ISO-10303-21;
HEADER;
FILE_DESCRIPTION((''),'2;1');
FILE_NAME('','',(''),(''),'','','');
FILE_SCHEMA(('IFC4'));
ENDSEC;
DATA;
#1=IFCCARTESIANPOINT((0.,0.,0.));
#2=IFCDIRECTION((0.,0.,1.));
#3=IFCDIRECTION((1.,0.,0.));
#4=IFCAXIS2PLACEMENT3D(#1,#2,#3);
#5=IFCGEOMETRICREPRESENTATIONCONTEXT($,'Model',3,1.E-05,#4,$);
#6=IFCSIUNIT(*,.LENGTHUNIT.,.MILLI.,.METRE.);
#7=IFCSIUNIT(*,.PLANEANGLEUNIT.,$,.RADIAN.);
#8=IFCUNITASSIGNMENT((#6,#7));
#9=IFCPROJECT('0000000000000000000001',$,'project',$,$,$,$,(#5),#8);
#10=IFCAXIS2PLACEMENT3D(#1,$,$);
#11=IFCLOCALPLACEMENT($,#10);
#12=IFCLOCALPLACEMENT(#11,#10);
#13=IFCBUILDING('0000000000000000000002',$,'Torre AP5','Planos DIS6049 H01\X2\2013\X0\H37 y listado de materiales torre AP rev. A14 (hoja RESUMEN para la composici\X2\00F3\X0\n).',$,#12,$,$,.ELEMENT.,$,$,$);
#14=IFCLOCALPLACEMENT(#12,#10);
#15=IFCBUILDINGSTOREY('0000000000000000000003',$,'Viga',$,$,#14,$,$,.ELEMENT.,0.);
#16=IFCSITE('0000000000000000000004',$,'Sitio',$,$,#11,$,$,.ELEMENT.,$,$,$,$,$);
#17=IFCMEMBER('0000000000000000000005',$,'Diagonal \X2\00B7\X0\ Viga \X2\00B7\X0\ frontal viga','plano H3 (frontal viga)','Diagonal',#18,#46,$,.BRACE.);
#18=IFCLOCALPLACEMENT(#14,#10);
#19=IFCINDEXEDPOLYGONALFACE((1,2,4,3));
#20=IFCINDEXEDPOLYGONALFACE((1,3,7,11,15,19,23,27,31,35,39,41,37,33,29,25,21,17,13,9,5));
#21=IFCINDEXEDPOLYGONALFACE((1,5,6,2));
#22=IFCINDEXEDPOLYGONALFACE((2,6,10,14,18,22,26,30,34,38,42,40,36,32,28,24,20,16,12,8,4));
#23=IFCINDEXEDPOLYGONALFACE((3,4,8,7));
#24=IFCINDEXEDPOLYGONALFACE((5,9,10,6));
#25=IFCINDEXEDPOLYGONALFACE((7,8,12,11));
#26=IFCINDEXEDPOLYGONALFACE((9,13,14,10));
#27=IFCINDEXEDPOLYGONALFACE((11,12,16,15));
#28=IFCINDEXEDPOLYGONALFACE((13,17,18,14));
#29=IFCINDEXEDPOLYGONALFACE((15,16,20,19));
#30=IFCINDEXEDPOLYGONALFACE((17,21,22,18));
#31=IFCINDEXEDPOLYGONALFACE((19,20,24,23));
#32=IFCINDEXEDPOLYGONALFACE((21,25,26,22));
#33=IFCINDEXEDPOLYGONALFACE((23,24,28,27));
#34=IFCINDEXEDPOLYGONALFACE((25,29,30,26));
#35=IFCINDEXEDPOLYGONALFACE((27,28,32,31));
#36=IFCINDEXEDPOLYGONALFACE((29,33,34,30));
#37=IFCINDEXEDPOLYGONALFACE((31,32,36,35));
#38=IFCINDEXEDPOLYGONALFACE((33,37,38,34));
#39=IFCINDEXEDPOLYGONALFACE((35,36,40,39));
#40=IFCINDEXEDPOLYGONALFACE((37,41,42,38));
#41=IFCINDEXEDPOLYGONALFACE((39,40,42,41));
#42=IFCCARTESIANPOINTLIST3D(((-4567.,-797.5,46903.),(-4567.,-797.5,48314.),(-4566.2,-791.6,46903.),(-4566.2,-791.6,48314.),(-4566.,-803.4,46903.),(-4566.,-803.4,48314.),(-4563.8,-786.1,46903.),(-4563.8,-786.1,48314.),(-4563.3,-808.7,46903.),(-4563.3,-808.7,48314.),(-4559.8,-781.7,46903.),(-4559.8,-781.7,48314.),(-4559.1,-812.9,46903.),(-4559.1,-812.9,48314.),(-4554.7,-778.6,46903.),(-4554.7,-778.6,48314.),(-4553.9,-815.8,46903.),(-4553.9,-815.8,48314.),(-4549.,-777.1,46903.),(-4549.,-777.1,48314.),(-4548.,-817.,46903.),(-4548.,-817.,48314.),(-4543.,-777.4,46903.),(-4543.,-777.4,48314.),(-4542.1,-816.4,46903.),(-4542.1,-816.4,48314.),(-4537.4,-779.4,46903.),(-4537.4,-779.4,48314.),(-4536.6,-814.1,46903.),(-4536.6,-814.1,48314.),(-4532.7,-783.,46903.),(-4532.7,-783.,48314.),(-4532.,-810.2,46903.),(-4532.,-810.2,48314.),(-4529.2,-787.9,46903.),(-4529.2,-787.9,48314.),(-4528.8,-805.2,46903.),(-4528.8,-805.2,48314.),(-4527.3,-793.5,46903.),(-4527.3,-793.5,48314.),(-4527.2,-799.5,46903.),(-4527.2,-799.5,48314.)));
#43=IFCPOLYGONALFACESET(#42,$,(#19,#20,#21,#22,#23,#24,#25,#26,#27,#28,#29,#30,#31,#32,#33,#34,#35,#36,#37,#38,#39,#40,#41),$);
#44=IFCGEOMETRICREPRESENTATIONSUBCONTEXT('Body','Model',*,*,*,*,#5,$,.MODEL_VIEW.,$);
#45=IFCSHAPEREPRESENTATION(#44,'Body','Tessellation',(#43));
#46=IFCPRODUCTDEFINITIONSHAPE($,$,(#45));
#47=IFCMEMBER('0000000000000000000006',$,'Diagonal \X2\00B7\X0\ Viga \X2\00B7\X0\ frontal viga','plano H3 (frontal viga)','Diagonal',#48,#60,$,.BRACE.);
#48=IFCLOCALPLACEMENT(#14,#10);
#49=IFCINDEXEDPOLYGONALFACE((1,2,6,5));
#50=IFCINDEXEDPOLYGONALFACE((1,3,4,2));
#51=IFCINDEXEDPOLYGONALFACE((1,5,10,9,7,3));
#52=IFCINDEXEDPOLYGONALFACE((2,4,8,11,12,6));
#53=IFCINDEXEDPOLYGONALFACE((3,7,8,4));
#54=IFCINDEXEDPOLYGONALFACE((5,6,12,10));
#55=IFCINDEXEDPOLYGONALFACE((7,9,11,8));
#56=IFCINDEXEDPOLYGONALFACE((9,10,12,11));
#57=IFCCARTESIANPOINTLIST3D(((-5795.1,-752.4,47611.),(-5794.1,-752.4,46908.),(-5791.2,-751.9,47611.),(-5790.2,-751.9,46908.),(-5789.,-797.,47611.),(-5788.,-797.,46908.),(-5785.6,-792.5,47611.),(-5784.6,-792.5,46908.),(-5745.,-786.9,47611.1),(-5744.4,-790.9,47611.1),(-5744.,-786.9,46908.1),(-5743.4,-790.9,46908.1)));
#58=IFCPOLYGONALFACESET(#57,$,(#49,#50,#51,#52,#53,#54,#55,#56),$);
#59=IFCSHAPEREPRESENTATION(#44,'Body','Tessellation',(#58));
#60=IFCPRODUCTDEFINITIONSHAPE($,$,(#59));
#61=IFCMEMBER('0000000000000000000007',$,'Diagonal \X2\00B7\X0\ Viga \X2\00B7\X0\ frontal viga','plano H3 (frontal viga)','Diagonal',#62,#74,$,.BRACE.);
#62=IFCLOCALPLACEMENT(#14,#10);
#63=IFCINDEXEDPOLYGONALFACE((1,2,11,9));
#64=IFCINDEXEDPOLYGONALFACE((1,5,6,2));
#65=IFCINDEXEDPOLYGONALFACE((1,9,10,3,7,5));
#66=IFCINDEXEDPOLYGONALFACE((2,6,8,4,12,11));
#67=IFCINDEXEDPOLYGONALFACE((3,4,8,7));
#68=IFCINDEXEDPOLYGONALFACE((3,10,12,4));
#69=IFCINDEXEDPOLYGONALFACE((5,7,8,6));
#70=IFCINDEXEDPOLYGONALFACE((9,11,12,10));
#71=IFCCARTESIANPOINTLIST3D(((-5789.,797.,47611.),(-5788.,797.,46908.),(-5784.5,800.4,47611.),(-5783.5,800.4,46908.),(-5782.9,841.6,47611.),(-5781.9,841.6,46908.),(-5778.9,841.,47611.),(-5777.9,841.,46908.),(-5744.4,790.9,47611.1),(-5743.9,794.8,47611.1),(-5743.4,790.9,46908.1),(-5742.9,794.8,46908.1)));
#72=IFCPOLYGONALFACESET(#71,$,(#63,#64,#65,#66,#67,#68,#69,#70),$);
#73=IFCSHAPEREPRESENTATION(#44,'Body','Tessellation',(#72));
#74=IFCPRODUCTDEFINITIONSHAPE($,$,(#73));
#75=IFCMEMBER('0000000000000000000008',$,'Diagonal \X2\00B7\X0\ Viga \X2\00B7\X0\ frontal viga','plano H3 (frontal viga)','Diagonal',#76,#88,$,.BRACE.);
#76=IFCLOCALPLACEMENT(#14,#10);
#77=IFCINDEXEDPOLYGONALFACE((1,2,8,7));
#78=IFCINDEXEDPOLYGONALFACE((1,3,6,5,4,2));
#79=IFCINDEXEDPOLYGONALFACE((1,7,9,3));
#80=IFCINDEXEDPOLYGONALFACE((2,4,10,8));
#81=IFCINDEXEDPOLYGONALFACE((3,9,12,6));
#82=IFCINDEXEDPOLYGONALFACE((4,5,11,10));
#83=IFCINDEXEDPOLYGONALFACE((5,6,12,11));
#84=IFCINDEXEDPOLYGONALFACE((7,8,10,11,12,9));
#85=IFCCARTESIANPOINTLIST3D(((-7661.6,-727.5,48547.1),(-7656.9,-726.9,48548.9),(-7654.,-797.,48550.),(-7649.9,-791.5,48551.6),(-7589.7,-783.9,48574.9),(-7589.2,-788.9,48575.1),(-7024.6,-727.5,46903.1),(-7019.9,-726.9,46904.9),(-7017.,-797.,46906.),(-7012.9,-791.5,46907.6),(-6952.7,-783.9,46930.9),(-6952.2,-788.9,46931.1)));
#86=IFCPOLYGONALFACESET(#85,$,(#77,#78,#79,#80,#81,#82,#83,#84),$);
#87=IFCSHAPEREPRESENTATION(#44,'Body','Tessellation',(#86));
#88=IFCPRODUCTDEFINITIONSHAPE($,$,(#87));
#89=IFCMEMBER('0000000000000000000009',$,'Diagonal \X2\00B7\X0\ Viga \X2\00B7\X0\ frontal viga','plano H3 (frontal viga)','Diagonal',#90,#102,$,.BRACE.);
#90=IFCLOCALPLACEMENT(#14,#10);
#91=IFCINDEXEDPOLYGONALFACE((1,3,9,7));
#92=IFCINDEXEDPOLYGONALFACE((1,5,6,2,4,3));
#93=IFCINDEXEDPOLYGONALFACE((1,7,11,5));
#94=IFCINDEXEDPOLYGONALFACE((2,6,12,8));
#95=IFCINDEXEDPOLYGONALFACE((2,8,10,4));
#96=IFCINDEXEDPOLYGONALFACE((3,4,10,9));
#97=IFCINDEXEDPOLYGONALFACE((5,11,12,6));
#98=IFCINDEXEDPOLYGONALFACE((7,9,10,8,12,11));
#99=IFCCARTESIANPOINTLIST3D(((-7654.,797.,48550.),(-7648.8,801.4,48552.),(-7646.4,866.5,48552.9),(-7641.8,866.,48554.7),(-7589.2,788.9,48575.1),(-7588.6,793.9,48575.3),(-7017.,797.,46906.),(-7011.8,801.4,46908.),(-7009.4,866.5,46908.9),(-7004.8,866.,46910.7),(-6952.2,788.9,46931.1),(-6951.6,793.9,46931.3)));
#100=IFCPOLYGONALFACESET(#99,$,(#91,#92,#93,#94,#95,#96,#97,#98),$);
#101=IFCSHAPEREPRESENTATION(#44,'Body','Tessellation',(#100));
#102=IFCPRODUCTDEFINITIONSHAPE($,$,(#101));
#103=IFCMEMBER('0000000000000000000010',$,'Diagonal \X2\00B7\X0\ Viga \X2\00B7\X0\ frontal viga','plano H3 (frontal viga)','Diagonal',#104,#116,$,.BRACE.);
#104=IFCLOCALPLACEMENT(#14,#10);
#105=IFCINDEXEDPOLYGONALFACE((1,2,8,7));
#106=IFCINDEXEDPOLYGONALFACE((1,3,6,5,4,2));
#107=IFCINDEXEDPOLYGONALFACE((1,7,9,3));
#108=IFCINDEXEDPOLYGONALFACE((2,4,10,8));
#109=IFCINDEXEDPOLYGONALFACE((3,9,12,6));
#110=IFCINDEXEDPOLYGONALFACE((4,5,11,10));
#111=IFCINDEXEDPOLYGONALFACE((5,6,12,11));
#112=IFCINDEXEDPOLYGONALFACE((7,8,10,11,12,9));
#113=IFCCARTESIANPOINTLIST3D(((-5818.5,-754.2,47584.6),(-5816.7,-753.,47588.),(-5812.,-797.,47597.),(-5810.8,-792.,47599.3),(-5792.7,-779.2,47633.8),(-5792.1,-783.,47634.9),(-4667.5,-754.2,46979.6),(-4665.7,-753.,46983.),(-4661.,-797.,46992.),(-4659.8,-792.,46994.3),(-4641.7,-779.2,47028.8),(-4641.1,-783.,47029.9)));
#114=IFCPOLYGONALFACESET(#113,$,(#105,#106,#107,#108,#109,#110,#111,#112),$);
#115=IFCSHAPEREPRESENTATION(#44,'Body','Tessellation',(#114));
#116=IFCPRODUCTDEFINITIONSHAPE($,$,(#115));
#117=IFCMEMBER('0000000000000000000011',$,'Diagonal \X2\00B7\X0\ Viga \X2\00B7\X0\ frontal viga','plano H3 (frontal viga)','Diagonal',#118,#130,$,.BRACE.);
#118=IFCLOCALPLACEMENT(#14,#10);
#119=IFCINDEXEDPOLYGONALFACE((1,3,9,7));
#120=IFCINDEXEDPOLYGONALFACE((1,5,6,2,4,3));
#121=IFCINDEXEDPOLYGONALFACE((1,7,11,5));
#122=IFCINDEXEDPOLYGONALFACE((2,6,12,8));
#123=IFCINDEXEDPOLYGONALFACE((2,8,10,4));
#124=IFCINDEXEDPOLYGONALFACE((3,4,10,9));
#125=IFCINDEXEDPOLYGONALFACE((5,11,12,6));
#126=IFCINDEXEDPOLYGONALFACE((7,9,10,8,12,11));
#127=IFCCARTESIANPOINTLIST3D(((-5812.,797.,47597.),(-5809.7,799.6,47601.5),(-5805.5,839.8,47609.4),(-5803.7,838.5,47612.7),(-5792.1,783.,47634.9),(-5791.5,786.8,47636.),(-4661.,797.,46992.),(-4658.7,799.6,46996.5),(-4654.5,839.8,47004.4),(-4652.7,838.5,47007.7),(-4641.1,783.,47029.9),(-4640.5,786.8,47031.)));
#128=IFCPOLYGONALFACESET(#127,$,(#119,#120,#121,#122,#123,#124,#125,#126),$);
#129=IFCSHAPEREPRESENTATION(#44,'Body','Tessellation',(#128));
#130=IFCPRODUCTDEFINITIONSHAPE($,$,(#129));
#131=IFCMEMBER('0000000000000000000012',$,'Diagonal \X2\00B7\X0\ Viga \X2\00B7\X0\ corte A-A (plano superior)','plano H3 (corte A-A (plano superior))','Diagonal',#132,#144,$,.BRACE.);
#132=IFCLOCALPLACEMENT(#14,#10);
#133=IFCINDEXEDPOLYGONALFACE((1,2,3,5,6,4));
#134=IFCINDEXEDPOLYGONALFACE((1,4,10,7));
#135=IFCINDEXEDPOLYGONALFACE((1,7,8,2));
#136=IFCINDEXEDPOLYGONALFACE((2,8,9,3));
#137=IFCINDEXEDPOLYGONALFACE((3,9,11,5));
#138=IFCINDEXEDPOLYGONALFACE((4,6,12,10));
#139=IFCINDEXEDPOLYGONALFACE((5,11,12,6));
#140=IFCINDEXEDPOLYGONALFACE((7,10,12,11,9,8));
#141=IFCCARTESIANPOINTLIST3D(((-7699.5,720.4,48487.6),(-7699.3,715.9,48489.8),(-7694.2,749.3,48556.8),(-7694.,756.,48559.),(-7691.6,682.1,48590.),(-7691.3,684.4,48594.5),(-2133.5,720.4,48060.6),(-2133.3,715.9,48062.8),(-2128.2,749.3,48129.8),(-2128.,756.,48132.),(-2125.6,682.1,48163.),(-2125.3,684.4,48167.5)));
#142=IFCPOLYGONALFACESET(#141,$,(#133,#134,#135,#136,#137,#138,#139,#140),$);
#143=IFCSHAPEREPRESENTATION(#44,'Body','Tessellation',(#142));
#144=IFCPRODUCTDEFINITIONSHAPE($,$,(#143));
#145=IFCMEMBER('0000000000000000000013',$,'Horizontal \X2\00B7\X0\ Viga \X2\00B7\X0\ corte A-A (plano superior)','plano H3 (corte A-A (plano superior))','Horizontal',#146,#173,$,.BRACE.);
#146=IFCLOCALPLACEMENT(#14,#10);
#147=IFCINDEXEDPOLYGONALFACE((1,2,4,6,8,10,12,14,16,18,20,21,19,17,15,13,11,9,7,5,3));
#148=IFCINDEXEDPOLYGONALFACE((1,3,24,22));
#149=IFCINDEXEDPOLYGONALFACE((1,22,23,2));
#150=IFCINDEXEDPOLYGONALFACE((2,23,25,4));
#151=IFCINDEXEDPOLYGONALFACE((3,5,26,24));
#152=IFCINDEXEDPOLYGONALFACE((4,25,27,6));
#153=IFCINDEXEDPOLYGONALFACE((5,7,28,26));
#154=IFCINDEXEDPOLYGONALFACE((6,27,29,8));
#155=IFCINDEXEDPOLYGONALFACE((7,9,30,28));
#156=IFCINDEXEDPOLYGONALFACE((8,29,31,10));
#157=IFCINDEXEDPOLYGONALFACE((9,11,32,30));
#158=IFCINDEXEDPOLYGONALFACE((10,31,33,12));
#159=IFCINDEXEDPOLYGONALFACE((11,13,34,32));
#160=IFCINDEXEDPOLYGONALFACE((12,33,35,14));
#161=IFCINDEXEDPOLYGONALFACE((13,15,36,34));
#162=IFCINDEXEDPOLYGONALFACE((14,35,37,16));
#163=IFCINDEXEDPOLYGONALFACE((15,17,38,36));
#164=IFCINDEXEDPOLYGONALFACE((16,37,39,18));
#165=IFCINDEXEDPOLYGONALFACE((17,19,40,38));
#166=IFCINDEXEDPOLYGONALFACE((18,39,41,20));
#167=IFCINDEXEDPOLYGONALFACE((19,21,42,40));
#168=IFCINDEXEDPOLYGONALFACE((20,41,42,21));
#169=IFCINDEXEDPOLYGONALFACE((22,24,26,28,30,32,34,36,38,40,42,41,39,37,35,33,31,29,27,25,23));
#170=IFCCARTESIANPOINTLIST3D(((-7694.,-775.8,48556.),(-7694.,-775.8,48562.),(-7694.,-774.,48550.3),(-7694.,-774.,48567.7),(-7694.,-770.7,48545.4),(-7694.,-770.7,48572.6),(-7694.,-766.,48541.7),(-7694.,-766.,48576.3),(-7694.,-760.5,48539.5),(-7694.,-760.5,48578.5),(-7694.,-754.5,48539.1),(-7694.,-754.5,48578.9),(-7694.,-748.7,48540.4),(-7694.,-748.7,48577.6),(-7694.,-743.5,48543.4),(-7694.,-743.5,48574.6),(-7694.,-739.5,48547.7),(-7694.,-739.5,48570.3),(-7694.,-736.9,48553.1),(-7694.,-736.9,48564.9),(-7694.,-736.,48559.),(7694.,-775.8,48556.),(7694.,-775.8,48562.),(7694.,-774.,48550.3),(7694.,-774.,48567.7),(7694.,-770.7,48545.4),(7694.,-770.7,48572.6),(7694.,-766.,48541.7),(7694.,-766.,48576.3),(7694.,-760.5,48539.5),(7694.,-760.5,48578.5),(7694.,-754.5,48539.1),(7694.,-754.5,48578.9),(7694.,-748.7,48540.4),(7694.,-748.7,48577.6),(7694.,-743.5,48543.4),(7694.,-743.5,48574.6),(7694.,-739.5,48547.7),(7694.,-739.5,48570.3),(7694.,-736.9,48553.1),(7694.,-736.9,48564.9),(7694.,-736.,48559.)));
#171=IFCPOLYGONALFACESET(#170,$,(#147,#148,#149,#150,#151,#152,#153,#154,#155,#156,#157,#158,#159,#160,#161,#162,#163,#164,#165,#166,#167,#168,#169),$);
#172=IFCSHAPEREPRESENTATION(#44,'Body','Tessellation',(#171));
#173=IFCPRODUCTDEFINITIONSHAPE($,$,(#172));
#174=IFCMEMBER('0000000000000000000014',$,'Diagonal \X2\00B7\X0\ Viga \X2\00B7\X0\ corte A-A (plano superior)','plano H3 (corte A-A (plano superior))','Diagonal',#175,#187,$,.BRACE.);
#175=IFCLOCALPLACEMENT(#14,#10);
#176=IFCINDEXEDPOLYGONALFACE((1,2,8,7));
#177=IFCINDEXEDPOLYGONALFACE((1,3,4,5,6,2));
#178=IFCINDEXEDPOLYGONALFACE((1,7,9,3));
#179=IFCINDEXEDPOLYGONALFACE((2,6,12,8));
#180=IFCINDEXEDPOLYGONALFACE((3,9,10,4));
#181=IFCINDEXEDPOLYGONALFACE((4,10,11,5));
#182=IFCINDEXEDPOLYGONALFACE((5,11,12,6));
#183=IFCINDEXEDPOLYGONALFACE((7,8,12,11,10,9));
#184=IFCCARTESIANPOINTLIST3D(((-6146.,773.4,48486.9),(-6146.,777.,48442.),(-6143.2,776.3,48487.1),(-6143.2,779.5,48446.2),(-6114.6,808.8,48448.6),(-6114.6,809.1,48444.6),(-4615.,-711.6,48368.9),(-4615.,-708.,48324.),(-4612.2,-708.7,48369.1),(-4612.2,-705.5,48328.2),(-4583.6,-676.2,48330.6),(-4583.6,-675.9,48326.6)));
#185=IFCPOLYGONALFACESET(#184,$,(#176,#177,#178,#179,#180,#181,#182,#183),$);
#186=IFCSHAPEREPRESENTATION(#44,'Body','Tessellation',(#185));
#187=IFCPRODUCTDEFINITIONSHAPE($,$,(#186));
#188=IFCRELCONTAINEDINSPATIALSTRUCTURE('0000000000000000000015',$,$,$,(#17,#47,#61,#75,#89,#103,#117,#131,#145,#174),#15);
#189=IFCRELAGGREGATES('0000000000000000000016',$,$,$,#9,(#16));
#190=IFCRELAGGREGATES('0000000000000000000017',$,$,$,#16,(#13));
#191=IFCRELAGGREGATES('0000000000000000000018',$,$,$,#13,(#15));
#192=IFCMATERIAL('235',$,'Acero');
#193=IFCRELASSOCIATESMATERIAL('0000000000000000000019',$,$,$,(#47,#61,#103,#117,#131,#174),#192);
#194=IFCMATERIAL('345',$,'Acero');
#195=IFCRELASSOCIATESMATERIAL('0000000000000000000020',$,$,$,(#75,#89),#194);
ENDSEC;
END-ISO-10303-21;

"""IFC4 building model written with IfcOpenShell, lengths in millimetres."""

from ifc_helpers import new_model, si_unit, frame, frame_2d, origin, origin_with_axes, place, context, subcontext, project, spatial, circle, l_section, extrude, material, element, save


model = new_model("IFC4")

# Units and contexts
model_context = context("Model", 3, precision=1e-05, world=origin_with_axes())
body_context = subcontext(model_context, "Body", "Model", "MODEL_VIEW")
ifc_project = project(units=[si_unit("LENGTHUNIT", "METRE", prefix="MILLI"), si_unit("PLANEANGLEUNIT", "RADIAN")], contexts=[model_context])

# Site, building, storey
site_placement = place(None, origin())
site = spatial("IfcSite", under=ifc_project, at=site_placement, Name="Sitio", CompositionType="ELEMENT")
building_placement = place(site_placement, origin())
building = spatial("IfcBuilding", under=site, at=building_placement, Name="Torre AP5", Description="Planos DIS6049 H01–H37 y listado de materiales torre AP rev. A14 (hoja RESUMEN para la composición).", CompositionType="ELEMENT")
storey_placement = place(building_placement, origin())
storey = spatial("IfcBuildingStorey", under=building, at=storey_placement, Name="Viga", CompositionType="ELEMENT", Elevation=0.0)

# Members
ifc_material_1 = material(Name="345", Category="Acero")
member_1_placement = place(storey_placement, frame((-4547.0, -797.0, 46903.0), z_axis=(0.0, 0.0, 1.0), x_axis=(0.984984, 0.172648, 0.0)))
element("IfcMember", 1, at=member_1_placement, inside=storey, Name="Diagonal · Viga · frontal viga", Description="plano H3 (frontal viga)", ObjectType="Diagonal", PredefinedType="BRACE", context=body_context, shape_type="SweptSolid", body=[
    extrude(circle(Radius=20.0), None, (0.0, 0.0, 1.0), 1411.0),
])
ifc_material_2 = material(Name="235", Category="Acero")
for number, where, z_axis, x_axis, name in (
    (2, (-5788.0, -797.0, 46908.0), (-0.001422, 0.0, 0.999999), (0.990653, 0.1364, 0.001409), "Diagonal · Viga · frontal viga"),
    (3, (-5788.0, 797.0, 46908.0), (-0.001422, 0.0, 0.999999), (0.990653, -0.1364, 0.001409), "Diagonal · Viga · frontal viga"),
):
    element("IfcMember", number, at=place(storey_placement, frame(where, z_axis=z_axis, x_axis=x_axis)), inside=storey, material=ifc_material_2, Name=name, Description="plano H3 (frontal viga)", ObjectType="Diagonal", PredefinedType="BRACE", context=body_context, shape_type="SweptSolid", body=[
        extrude(l_section(Depth=45.0, Width=45.0, Thickness=4.0, at=frame_2d((22.5, 22.5))), None, (0.0, 0.0, 1.0), 703.0),
    ])
for number, where, z_axis, x_axis, name in (
    (4, (-7017.0, -797.0, 46906.0), (-0.361296, 0.0, 0.932451), (0.926185, 0.115738, 0.358868), "Diagonal · Viga · frontal viga"),
    (5, (-7017.0, 797.0, 46906.0), (-0.361296, 0.0, 0.932451), (0.926185, -0.115738, 0.358868), "Diagonal · Viga · frontal viga"),
):
    element("IfcMember", number, at=place(storey_placement, frame(where, z_axis=z_axis, x_axis=x_axis)), inside=storey, material=ifc_material_1, Name=name, Description="plano H3 (frontal viga)", ObjectType="Diagonal", PredefinedType="BRACE", context=body_context, shape_type="SweptSolid", body=[
        extrude(l_section(Depth=70.0, Width=70.0, Thickness=5.0, at=frame_2d((35.0, 35.0))), None, (0.0, 0.0, 1.0), 1763.1),
    ])
for number, where, z_axis, x_axis, name in (
    (6, (-4661.0, -797.0, 46992.0), (-0.885168, 0.0, 0.465271), (0.442212, 0.310911, 0.841299), "Diagonal · Viga · frontal viga"),
    (7, (-4661.0, 797.0, 46992.0), (-0.885168, 0.0, 0.465271), (0.442212, -0.310911, 0.841299), "Diagonal · Viga · frontal viga"),
):
    element("IfcMember", number, at=place(storey_placement, frame(where, z_axis=z_axis, x_axis=x_axis)), inside=storey, material=ifc_material_2, Name=name, Description="plano H3 (frontal viga)", ObjectType="Diagonal", PredefinedType="BRACE", context=body_context, shape_type="SweptSolid", body=[
        extrude(l_section(Depth=45.0, Width=45.0, Thickness=4.0, at=frame_2d((22.5, 22.5))), None, (0.0, 0.0, 1.0), 1300.3),
    ])
member_2_placement = place(storey_placement, frame((-7694.0, 756.0, 48559.0), z_axis=(0.99707, 0.0, -0.076491), x_axis=(0.034037, -0.895539, 0.443679)))
element("IfcMember", 8, at=member_2_placement, inside=storey, material=ifc_material_2, Name="Diagonal · Viga · corte A-A (plano superior)", Description="plano H3 (corte A-A (plano superior))", ObjectType="Diagonal", PredefinedType="BRACE", context=body_context, shape_type="SweptSolid", body=[
    extrude(l_section(Depth=80.0, Width=80.0, Thickness=5.0, at=frame_2d((40.0, 40.0))), None, (0.0, 0.0, 1.0), 5582.4),
])
member_3_placement = place(storey_placement, frame((-7694.0, -756.0, 48559.0), z_axis=(1.0, 0.0, 0.0), x_axis=(0.0, 1.0, 0.0)))
element("IfcMember", 9, at=member_3_placement, inside=storey, Name="Horizontal · Viga · corte A-A (plano superior)", Description="plano H3 (corte A-A (plano superior))", ObjectType="Horizontal", PredefinedType="BRACE", context=body_context, shape_type="SweptSolid", body=[
    extrude(circle(Radius=20.0), None, (0.0, 0.0, 1.0), 15388.0),
])
member_4_placement = place(storey_placement, frame((-6146.0, 777.0, 48442.0), z_axis=(0.716712, -0.695178, -0.05524), x_axis=(0.697369, 0.714402, 0.057503)))
element("IfcMember", 10, at=member_4_placement, inside=storey, material=ifc_material_2, Name="Diagonal · Viga · corte A-A (plano superior)", Description="plano H3 (corte A-A (plano superior))", ObjectType="Diagonal", PredefinedType="BRACE", context=body_context, shape_type="SweptSolid", body=[
    extrude(l_section(Depth=45.0, Width=45.0, Thickness=4.0, at=frame_2d((22.5, 22.5))), None, (0.0, 0.0, 1.0), 2136.1),
])

save(model, "model.ifc")
